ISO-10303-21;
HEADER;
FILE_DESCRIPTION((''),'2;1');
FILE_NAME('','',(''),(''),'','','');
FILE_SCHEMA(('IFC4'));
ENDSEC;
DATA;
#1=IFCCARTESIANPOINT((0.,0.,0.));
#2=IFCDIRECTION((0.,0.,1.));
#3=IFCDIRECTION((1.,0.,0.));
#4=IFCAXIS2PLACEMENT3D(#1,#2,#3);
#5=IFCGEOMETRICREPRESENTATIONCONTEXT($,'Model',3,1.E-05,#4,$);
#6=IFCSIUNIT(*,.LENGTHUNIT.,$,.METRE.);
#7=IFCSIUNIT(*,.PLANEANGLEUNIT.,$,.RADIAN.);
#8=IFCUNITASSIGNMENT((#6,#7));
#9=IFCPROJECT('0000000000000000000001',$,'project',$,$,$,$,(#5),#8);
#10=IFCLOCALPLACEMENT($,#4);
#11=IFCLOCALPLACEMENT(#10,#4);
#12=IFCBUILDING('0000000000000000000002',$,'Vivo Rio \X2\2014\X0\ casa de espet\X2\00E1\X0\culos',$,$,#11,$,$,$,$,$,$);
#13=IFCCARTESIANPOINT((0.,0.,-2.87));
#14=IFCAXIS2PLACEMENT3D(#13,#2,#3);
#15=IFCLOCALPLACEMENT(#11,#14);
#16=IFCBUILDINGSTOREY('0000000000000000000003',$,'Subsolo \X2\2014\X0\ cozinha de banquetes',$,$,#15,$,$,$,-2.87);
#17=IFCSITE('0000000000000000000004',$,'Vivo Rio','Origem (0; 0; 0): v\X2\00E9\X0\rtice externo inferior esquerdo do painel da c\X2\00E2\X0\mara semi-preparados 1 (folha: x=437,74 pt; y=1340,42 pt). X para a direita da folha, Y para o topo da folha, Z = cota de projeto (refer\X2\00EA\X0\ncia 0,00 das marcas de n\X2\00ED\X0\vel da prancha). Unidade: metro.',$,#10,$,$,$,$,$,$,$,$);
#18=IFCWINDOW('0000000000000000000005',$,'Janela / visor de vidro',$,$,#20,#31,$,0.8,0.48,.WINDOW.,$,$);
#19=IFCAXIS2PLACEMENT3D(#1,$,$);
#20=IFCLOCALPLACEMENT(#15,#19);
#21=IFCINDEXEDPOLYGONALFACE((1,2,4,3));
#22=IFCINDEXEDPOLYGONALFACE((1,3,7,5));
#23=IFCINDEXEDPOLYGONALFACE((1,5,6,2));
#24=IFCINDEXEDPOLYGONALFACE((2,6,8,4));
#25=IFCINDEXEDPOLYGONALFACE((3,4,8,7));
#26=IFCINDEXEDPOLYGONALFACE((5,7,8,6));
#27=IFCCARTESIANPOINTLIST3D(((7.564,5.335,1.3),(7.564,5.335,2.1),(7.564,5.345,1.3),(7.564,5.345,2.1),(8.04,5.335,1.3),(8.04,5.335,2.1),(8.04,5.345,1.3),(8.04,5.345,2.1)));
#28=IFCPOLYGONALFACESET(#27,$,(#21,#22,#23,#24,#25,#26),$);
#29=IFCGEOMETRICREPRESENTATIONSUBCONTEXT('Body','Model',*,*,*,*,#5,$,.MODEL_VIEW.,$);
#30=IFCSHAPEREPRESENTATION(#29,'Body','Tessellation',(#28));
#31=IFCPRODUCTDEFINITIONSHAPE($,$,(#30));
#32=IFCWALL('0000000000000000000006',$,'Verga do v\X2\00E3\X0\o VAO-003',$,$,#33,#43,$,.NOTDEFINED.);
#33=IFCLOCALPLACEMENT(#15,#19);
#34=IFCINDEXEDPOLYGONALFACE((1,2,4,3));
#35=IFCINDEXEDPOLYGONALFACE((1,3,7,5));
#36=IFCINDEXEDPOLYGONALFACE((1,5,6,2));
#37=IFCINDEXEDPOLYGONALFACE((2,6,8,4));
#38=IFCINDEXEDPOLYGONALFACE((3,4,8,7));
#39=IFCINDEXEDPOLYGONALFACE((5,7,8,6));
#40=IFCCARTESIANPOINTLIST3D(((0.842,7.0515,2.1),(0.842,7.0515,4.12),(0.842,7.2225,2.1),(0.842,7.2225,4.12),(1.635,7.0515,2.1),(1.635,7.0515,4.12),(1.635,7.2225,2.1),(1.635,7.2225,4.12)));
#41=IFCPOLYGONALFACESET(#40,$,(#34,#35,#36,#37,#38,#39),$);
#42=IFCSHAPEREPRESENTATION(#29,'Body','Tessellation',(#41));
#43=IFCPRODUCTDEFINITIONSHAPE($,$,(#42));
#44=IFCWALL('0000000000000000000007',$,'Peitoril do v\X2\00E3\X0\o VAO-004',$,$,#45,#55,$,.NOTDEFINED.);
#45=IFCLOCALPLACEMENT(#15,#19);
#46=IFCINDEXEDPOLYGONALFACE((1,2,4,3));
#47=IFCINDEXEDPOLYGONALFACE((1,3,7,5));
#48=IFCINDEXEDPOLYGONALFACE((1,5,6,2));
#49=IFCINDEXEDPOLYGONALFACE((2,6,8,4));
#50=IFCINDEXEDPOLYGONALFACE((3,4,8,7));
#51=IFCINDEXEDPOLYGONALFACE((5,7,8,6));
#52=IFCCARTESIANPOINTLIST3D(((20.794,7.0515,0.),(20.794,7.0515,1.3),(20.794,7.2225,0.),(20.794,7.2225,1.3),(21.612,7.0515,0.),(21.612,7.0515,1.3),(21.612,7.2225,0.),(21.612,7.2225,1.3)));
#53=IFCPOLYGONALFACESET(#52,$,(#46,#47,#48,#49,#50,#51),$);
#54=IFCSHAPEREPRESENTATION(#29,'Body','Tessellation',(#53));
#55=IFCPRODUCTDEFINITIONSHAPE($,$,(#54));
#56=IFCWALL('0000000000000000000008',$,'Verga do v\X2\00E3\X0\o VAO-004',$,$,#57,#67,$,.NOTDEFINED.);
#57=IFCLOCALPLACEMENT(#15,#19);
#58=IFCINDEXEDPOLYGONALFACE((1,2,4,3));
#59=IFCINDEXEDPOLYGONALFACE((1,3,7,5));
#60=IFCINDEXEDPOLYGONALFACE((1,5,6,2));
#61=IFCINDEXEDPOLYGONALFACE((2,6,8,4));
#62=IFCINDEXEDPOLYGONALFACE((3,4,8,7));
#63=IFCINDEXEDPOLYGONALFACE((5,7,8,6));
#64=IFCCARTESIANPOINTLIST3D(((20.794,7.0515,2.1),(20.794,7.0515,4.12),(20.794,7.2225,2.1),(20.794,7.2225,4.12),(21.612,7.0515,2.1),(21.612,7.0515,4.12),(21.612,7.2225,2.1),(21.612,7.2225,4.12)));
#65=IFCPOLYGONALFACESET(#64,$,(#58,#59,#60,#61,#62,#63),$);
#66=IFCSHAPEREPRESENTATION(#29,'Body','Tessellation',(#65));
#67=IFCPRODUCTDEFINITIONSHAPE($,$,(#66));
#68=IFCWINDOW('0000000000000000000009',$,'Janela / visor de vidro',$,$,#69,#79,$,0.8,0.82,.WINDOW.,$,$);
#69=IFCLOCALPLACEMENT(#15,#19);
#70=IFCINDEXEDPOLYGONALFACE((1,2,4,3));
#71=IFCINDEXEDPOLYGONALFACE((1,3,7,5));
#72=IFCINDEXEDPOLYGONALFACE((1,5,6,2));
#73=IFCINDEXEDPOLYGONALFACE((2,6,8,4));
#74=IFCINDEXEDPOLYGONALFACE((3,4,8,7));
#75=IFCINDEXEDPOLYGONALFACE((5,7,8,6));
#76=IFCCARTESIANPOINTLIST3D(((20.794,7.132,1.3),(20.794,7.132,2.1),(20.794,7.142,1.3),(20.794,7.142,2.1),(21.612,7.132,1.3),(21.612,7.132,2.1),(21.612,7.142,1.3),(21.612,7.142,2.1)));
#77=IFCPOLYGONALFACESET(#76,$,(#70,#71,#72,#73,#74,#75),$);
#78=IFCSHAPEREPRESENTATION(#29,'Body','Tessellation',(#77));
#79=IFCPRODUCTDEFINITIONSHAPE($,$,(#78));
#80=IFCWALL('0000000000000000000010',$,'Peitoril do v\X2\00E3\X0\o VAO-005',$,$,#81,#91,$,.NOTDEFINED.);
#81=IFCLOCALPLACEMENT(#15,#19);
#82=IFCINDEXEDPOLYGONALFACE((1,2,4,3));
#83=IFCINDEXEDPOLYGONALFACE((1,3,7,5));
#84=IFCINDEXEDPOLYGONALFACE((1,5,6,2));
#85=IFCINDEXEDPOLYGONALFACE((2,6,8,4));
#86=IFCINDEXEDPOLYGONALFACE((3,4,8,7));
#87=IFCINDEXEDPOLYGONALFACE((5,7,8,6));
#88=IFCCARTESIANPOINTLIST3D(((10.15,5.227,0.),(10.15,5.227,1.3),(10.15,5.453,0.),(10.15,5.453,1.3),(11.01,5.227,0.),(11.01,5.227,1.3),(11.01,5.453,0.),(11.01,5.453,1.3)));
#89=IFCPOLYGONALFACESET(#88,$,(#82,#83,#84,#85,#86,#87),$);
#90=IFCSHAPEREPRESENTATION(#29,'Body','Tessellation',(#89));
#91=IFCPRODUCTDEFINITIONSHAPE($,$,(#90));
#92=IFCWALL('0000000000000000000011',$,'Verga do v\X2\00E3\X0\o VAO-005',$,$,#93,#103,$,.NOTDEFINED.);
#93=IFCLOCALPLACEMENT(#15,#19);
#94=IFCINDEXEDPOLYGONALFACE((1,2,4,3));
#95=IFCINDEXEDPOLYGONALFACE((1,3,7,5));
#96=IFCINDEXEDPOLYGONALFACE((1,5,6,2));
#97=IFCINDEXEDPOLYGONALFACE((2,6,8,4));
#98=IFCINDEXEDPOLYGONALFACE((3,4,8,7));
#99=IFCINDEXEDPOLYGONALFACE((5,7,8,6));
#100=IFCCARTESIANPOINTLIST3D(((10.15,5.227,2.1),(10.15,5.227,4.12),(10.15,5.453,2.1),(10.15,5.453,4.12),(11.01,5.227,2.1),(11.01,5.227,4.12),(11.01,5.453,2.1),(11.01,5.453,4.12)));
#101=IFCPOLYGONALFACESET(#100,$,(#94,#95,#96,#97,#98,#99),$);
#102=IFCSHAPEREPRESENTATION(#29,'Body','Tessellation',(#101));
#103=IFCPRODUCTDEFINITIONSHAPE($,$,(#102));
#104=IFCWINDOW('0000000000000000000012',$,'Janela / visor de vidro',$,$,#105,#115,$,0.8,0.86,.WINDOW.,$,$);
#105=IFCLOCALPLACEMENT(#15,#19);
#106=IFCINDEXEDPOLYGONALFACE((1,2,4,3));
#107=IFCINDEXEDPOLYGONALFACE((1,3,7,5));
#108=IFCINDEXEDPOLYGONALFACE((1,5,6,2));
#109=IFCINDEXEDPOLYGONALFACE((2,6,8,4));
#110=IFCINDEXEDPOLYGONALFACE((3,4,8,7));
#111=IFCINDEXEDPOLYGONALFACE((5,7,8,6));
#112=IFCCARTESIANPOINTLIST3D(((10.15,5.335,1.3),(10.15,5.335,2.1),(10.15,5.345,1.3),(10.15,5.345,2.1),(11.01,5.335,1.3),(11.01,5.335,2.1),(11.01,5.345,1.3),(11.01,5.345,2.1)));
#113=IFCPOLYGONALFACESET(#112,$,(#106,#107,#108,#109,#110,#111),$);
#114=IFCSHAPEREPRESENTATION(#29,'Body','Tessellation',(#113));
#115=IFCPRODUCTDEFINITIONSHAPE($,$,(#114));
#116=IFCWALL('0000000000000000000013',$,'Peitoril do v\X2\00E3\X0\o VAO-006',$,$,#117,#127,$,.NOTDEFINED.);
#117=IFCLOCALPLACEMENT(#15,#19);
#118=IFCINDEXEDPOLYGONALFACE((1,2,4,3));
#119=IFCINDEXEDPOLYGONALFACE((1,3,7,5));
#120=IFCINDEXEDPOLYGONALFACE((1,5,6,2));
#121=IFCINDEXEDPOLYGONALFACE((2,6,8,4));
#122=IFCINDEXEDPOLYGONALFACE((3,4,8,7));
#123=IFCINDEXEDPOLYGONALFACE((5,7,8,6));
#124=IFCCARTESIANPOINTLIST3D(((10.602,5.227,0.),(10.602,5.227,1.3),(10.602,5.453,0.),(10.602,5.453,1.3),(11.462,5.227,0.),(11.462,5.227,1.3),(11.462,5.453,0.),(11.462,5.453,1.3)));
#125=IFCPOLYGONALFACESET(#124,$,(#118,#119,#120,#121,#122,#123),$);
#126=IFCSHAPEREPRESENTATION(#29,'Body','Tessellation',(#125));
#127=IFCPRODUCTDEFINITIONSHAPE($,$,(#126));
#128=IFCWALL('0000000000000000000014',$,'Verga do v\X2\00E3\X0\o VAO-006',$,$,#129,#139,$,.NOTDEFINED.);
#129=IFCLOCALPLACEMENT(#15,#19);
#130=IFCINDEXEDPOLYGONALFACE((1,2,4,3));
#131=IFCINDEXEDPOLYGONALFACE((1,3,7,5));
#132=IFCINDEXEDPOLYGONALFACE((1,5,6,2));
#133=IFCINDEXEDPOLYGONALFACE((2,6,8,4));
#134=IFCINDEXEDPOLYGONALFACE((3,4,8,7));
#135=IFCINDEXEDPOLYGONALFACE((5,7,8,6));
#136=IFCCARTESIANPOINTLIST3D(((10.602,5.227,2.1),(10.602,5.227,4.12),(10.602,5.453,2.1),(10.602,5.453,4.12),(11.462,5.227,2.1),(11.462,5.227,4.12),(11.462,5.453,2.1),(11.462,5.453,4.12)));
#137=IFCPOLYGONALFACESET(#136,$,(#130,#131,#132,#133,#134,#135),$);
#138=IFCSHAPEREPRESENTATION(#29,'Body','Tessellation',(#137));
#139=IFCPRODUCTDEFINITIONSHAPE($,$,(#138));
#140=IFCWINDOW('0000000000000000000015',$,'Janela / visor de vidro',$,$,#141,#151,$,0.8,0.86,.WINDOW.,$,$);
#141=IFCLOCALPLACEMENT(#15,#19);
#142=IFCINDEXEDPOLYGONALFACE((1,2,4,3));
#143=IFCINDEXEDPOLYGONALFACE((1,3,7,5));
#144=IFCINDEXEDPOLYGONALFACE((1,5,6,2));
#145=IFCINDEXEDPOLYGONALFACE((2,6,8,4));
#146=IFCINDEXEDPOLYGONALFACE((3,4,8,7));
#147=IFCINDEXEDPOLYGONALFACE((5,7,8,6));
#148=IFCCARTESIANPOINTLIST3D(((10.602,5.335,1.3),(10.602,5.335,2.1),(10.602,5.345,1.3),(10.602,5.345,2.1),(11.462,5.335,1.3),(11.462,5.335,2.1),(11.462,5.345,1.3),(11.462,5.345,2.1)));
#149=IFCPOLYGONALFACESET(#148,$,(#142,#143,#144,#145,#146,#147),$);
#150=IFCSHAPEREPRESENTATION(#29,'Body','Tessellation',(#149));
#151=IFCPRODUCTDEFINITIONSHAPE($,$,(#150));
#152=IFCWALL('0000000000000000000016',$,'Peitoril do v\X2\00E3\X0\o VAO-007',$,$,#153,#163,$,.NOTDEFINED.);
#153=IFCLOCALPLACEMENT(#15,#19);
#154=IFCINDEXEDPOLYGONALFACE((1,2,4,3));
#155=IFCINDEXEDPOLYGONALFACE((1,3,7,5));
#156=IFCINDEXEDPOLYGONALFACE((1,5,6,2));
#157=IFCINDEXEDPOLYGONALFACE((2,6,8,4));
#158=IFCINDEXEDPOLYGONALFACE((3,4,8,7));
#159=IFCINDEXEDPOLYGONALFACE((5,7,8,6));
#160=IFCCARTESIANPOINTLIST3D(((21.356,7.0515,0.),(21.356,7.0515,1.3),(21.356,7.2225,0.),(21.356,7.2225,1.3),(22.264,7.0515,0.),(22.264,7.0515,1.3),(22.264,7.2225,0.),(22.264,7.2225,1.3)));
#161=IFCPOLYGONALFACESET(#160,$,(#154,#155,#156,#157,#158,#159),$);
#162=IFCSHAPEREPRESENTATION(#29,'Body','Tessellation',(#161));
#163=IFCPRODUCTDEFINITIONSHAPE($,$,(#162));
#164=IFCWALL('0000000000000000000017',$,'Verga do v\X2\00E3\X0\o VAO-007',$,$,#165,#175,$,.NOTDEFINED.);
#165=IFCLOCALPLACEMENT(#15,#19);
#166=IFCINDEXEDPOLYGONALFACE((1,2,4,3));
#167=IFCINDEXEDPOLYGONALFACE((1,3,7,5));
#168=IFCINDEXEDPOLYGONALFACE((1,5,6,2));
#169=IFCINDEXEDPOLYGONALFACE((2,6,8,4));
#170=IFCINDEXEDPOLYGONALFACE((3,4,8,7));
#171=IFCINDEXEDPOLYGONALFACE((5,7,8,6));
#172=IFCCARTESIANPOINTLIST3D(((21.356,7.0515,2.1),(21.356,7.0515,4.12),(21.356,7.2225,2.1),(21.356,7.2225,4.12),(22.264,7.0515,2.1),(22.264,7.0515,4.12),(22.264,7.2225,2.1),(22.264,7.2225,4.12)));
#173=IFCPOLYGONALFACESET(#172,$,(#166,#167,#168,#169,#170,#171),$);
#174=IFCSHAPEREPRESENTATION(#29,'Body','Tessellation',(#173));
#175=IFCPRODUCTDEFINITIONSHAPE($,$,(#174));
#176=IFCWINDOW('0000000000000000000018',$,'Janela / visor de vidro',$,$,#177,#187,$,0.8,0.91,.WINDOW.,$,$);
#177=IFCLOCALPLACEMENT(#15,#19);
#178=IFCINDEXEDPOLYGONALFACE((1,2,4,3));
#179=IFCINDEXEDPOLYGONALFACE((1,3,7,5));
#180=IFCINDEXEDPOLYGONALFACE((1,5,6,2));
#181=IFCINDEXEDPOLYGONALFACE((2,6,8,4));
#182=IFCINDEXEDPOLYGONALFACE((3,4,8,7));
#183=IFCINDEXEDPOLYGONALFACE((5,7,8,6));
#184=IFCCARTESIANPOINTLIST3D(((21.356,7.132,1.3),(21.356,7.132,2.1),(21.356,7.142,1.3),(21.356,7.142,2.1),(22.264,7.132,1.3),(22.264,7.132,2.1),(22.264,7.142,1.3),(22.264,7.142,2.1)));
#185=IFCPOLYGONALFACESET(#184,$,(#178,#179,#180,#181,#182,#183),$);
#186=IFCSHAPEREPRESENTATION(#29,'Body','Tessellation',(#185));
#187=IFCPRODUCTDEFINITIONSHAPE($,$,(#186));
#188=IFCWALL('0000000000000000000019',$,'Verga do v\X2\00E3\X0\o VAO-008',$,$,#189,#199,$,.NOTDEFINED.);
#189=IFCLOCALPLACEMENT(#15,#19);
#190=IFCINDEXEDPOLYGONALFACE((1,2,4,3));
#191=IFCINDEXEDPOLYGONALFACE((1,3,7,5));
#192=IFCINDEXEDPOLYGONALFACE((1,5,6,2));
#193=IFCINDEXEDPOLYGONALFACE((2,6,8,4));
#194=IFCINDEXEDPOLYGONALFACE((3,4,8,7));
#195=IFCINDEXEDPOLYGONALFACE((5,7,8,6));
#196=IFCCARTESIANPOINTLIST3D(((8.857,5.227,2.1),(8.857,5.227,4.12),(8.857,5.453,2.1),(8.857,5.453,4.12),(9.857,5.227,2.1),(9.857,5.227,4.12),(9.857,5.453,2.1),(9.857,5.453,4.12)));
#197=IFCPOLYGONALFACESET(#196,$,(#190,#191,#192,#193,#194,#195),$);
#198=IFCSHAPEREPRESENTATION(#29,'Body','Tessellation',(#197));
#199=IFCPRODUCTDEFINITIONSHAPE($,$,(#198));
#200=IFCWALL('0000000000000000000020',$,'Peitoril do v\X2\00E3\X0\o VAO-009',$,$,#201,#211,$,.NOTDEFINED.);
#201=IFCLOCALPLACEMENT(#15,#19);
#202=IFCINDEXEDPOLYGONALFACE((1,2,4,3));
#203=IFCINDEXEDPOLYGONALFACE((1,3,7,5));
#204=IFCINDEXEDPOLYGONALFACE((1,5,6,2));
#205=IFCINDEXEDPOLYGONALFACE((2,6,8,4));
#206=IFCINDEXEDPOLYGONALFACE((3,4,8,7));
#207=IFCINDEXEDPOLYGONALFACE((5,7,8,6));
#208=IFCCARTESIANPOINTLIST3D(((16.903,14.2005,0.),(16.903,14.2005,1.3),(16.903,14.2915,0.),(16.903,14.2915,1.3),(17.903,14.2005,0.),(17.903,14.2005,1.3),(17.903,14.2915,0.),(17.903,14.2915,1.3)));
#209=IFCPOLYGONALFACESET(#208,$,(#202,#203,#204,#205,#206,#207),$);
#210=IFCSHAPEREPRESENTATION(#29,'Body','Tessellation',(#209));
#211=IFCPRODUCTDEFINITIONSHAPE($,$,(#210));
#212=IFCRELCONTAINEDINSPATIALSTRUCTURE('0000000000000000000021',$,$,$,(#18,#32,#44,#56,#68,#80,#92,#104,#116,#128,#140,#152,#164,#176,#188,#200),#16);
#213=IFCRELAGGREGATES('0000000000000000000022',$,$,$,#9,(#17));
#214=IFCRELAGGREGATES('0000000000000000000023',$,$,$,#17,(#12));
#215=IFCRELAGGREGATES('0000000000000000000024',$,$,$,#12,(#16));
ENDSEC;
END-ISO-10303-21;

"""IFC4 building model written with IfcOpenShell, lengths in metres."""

from ifc_helpers import new_model, si_unit, frame, origin_with_axes, origin_2d, place, context, subcontext, project, spatial, rectangle, extrude, element, save


model = new_model("IFC4")

# Units and contexts
model_context = context("Model", 3, precision=1e-05, world=origin_with_axes())
body_context = subcontext(model_context, "Body", "Model", "MODEL_VIEW")
ifc_project = project(units=[si_unit("LENGTHUNIT", "METRE"), si_unit("PLANEANGLEUNIT", "RADIAN")], contexts=[model_context])

# Site, building, storey
site_placement = place(None, origin_with_axes())
site = spatial("IfcSite", under=ifc_project, at=site_placement, Name="Vivo Rio", Description="Origem (0; 0; 0): vértice externo inferior esquerdo do painel da câmara semi-preparados 1 (folha: x=437,74 pt; y=1340,42 pt). X para a direita da folha, Y para o topo da folha, Z = cota de projeto (referência 0,00 das marcas de nível da prancha). Unidade: metro.")
building_placement = place(site_placement, origin_with_axes())
building = spatial("IfcBuilding", under=site, at=building_placement, Name="Vivo Rio — casa de espetáculos")
storey_placement = place(building_placement, frame((0.0, 0.0, -2.87), z_axis=(0.0, 0.0, 1.0), x_axis=(1.0, 0.0, 0.0)))
storey = spatial("IfcBuildingStorey", under=building, at=storey_placement, Name="Subsolo — cozinha de banquetes", Elevation=-2.87)

# Window
window_1_placement = place(storey_placement, origin_with_axes())
element("IfcWindow", 1, at=window_1_placement, inside=storey, Name="Janela / visor de vidro", OverallHeight=0.8, OverallWidth=0.48, PredefinedType="WINDOW", context=body_context, shape_type="SweptSolid", body=[
    extrude(rectangle(XDim=0.476, YDim=0.01, at=origin_2d()), frame((7.802, 5.34, 1.3), z_axis=(0.0, 0.0, 1.0), x_axis=(1.0, 0.0, 0.0)), (0.0, 0.0, 1.0), 0.8),
])

# Walls
wall_1_placement = place(storey_placement, origin_with_axes())
element("IfcWall", 2, at=wall_1_placement, inside=storey, Name="Verga do vão VAO-003", PredefinedType="NOTDEFINED", context=body_context, shape_type="SweptSolid", body=[
    extrude(rectangle(XDim=0.793, YDim=0.171, at=origin_2d()), frame((1.2385, 7.137, 2.1), z_axis=(0.0, 0.0, 1.0), x_axis=(1.0, 0.0, 0.0)), (0.0, 0.0, 1.0), 2.02),
])
wall_2_placement = place(storey_placement, origin_with_axes())
element("IfcWall", 3, at=wall_2_placement, inside=storey, Name="Peitoril do vão VAO-004", PredefinedType="NOTDEFINED", context=body_context, shape_type="SweptSolid", body=[
    extrude(rectangle(XDim=0.818, YDim=0.171, at=origin_2d()), frame((21.203, 7.137, 0.0), z_axis=(0.0, 0.0, 1.0), x_axis=(1.0, 0.0, 0.0)), (0.0, 0.0, 1.0), 1.3),
])
wall_3_placement = place(storey_placement, origin_with_axes())
element("IfcWall", 4, at=wall_3_placement, inside=storey, Name="Verga do vão VAO-004", PredefinedType="NOTDEFINED", context=body_context, shape_type="SweptSolid", body=[
    extrude(rectangle(XDim=0.818, YDim=0.171, at=origin_2d()), frame((21.203, 7.137, 2.1), z_axis=(0.0, 0.0, 1.0), x_axis=(1.0, 0.0, 0.0)), (0.0, 0.0, 1.0), 2.02),
])

# Window
window_2_placement = place(storey_placement, origin_with_axes())
element("IfcWindow", 5, at=window_2_placement, inside=storey, Name="Janela / visor de vidro", OverallHeight=0.8, OverallWidth=0.82, PredefinedType="WINDOW", context=body_context, shape_type="SweptSolid", body=[
    extrude(rectangle(XDim=0.818, YDim=0.01, at=origin_2d()), frame((21.203, 7.137, 1.3), z_axis=(0.0, 0.0, 1.0), x_axis=(1.0, 0.0, 0.0)), (0.0, 0.0, 1.0), 0.8),
])

# Walls
wall_4_placement = place(storey_placement, origin_with_axes())
element("IfcWall", 6, at=wall_4_placement, inside=storey, Name="Peitoril do vão VAO-005", PredefinedType="NOTDEFINED", context=body_context, shape_type="SweptSolid", body=[
    extrude(rectangle(XDim=0.86, YDim=0.226, at=origin_2d()), frame((10.58, 5.34, 0.0), z_axis=(0.0, 0.0, 1.0), x_axis=(1.0, 0.0, 0.0)), (0.0, 0.0, 1.0), 1.3),
])
wall_5_placement = place(storey_placement, origin_with_axes())
element("IfcWall", 7, at=wall_5_placement, inside=storey, Name="Verga do vão VAO-005", PredefinedType="NOTDEFINED", context=body_context, shape_type="SweptSolid", body=[
    extrude(rectangle(XDim=0.86, YDim=0.226, at=origin_2d()), frame((10.58, 5.34, 2.1), z_axis=(0.0, 0.0, 1.0), x_axis=(1.0, 0.0, 0.0)), (0.0, 0.0, 1.0), 2.02),
])

# Window
window_3_placement = place(storey_placement, origin_with_axes())
element("IfcWindow", 8, at=window_3_placement, inside=storey, Name="Janela / visor de vidro", OverallHeight=0.8, OverallWidth=0.86, PredefinedType="WINDOW", context=body_context, shape_type="SweptSolid", body=[
    extrude(rectangle(XDim=0.86, YDim=0.01, at=origin_2d()), frame((10.58, 5.34, 1.3), z_axis=(0.0, 0.0, 1.0), x_axis=(1.0, 0.0, 0.0)), (0.0, 0.0, 1.0), 0.8),
])

# Walls
wall_6_placement = place(storey_placement, origin_with_axes())
element("IfcWall", 9, at=wall_6_placement, inside=storey, Name="Peitoril do vão VAO-006", PredefinedType="NOTDEFINED", context=body_context, shape_type="SweptSolid", body=[
    extrude(rectangle(XDim=0.86, YDim=0.226, at=origin_2d()), frame((11.032, 5.34, 0.0), z_axis=(0.0, 0.0, 1.0), x_axis=(1.0, 0.0, 0.0)), (0.0, 0.0, 1.0), 1.3),
])
wall_7_placement = place(storey_placement, origin_with_axes())
element("IfcWall", 10, at=wall_7_placement, inside=storey, Name="Verga do vão VAO-006", PredefinedType="NOTDEFINED", context=body_context, shape_type="SweptSolid", body=[
    extrude(rectangle(XDim=0.86, YDim=0.226, at=origin_2d()), frame((11.032, 5.34, 2.1), z_axis=(0.0, 0.0, 1.0), x_axis=(1.0, 0.0, 0.0)), (0.0, 0.0, 1.0), 2.02),
])

# Window
window_4_placement = place(storey_placement, origin_with_axes())
element("IfcWindow", 11, at=window_4_placement, inside=storey, Name="Janela / visor de vidro", OverallHeight=0.8, OverallWidth=0.86, PredefinedType="WINDOW", context=body_context, shape_type="SweptSolid", body=[
    extrude(rectangle(XDim=0.86, YDim=0.01, at=origin_2d()), frame((11.032, 5.34, 1.3), z_axis=(0.0, 0.0, 1.0), x_axis=(1.0, 0.0, 0.0)), (0.0, 0.0, 1.0), 0.8),
])

# Walls
wall_8_placement = place(storey_placement, origin_with_axes())
element("IfcWall", 12, at=wall_8_placement, inside=storey, Name="Peitoril do vão VAO-007", PredefinedType="NOTDEFINED", context=body_context, shape_type="SweptSolid", body=[
    extrude(rectangle(XDim=0.908, YDim=0.171, at=origin_2d()), frame((21.81, 7.137, 0.0), z_axis=(0.0, 0.0, 1.0), x_axis=(1.0, 0.0, 0.0)), (0.0, 0.0, 1.0), 1.3),
])
wall_9_placement = place(storey_placement, origin_with_axes())
element("IfcWall", 13, at=wall_9_placement, inside=storey, Name="Verga do vão VAO-007", PredefinedType="NOTDEFINED", context=body_context, shape_type="SweptSolid", body=[
    extrude(rectangle(XDim=0.908, YDim=0.171, at=origin_2d()), frame((21.81, 7.137, 2.1), z_axis=(0.0, 0.0, 1.0), x_axis=(1.0, 0.0, 0.0)), (0.0, 0.0, 1.0), 2.02),
])

# Window
window_5_placement = place(storey_placement, origin_with_axes())
element("IfcWindow", 14, at=window_5_placement, inside=storey, Name="Janela / visor de vidro", OverallHeight=0.8, OverallWidth=0.91, PredefinedType="WINDOW", context=body_context, shape_type="SweptSolid", body=[
    extrude(rectangle(XDim=0.908, YDim=0.01, at=origin_2d()), frame((21.81, 7.137, 1.3), z_axis=(0.0, 0.0, 1.0), x_axis=(1.0, 0.0, 0.0)), (0.0, 0.0, 1.0), 0.8),
])

# Walls
wall_10_placement = place(storey_placement, origin_with_axes())
element("IfcWall", 15, at=wall_10_placement, inside=storey, Name="Verga do vão VAO-008", PredefinedType="NOTDEFINED", context=body_context, shape_type="SweptSolid", body=[
    extrude(rectangle(XDim=1.0, YDim=0.226, at=origin_2d()), frame((9.357, 5.34, 2.1), z_axis=(0.0, 0.0, 1.0), x_axis=(1.0, 0.0, 0.0)), (0.0, 0.0, 1.0), 2.02),
])
wall_11_placement = place(storey_placement, origin_with_axes())
element("IfcWall", 16, at=wall_11_placement, inside=storey, Name="Peitoril do vão VAO-009", PredefinedType="NOTDEFINED", context=body_context, shape_type="SweptSolid", body=[
    extrude(rectangle(XDim=1.0, YDim=0.091, at=origin_2d()), frame((17.403, 14.246, 0.0), z_axis=(0.0, 0.0, 1.0), x_axis=(1.0, 0.0, 0.0)), (0.0, 0.0, 1.0), 1.3),
])

save(model, "model.ifc")
